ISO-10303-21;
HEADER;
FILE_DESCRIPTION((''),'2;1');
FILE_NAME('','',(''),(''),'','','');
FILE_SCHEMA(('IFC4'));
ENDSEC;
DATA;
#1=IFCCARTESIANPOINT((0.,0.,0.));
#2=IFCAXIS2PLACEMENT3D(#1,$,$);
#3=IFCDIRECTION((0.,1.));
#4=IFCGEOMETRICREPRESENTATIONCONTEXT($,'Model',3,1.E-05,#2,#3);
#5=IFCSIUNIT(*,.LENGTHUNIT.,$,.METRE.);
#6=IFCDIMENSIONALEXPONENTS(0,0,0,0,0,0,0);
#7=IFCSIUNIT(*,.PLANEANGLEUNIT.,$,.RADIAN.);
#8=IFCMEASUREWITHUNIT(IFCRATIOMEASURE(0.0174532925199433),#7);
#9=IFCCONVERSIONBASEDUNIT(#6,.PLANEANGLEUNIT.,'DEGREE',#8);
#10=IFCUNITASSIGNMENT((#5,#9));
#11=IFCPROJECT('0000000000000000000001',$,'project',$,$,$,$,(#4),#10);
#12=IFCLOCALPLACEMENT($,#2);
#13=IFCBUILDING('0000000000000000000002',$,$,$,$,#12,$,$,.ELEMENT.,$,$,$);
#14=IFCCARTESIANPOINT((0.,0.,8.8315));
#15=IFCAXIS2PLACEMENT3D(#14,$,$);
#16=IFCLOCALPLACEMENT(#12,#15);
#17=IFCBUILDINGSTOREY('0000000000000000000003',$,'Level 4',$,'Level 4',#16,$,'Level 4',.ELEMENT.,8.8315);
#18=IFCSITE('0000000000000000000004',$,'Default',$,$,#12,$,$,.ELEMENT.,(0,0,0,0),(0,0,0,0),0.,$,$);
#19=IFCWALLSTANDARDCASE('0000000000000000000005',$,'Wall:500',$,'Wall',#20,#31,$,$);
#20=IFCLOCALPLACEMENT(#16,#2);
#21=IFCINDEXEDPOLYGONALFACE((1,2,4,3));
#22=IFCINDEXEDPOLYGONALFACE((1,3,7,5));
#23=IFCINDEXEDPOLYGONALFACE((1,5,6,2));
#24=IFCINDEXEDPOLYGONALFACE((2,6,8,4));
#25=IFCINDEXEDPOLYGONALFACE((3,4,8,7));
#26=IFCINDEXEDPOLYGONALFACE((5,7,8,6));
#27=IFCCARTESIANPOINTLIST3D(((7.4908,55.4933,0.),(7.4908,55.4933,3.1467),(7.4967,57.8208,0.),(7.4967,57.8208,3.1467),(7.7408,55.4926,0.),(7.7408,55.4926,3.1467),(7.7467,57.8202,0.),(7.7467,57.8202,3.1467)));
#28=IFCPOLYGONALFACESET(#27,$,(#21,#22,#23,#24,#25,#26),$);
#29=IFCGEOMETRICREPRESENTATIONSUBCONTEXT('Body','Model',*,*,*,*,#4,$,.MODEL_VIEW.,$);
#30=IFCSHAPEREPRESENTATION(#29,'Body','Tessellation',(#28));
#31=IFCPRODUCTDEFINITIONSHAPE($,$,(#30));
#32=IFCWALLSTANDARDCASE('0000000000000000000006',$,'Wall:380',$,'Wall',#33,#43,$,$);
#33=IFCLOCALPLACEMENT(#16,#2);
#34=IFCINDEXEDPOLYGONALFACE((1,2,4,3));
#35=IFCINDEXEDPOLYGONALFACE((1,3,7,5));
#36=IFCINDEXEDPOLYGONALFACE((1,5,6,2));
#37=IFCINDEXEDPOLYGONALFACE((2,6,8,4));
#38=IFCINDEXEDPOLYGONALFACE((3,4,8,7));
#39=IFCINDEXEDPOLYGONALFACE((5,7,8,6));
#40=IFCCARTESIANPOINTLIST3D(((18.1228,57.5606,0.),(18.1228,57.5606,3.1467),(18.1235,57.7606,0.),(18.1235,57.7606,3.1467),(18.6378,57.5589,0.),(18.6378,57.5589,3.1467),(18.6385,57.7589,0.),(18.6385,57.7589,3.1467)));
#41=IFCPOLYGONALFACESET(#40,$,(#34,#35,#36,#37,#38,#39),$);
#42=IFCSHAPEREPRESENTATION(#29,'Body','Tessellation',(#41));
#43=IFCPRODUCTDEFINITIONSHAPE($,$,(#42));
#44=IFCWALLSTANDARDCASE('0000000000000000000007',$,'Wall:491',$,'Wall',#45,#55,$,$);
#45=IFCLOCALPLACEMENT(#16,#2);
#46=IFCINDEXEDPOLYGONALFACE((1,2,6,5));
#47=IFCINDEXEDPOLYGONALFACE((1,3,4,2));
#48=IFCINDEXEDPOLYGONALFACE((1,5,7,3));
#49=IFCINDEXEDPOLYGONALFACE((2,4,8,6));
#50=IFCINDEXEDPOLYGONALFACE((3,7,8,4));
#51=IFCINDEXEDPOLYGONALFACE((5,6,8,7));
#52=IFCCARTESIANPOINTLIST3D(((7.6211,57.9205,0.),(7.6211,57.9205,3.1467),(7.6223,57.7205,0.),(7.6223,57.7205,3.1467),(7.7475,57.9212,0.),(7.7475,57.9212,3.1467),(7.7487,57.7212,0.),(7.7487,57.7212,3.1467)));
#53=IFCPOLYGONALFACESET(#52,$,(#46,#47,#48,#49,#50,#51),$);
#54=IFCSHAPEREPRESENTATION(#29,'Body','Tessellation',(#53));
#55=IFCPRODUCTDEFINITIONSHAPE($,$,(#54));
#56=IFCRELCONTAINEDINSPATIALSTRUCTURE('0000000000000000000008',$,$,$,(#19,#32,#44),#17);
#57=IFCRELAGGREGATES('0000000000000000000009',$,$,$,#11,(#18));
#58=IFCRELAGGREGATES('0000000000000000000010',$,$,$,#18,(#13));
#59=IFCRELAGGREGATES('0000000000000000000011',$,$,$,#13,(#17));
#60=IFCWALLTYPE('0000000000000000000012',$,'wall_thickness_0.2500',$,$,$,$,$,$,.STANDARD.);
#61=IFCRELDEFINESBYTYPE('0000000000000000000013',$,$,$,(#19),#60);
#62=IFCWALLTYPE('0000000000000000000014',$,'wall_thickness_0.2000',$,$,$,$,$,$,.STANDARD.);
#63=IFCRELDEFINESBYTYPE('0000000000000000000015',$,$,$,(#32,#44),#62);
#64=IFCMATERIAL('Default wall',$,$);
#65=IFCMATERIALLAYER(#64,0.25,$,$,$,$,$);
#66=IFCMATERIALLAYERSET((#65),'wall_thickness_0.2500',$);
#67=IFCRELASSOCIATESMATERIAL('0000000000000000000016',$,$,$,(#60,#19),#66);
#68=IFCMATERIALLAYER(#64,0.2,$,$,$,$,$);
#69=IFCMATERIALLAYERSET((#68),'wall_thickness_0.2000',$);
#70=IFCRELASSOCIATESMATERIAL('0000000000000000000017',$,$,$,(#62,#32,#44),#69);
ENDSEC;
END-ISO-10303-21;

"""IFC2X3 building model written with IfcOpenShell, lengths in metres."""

from ifc_helpers import new_model, entity, si_unit, converted_unit, direction, frame, origin, place, context, subcontext, project, spatial, polyline, outline, extrude, material, layer, layer_set, layer_usage, type_object, element, save


model = new_model("IFC2X3")

# Units and contexts
model_context = context("Model", 3, precision=1e-05, world=origin(), true_north=direction((0.0, 1.0)))
body_context = subcontext(model_context, "Body", "Model", "MODEL_VIEW")
ifc_project = project(units=[si_unit("LENGTHUNIT", "METRE"), converted_unit("PLANEANGLEUNIT", "DEGREE", entity("IfcRatioMeasure", 0.0174532925199433), si_unit("PLANEANGLEUNIT", "RADIAN"), dimensions=[0, 0, 0, 0, 0, 0, 0])], contexts=[model_context])

# Site, building, storey
placement = place(None, origin())
site = spatial("IfcSite", under=ifc_project, at=placement, Name="Default", CompositionType="ELEMENT", RefLatitude=(0, 0, 0, 0), RefLongitude=(0, 0, 0, 0), RefElevation=0.0)
building = spatial("IfcBuilding", under=site, at=placement, CompositionType="ELEMENT")
storey_placement = place(placement, frame((0.0, 0.0, 8.8315)))
storey = spatial("IfcBuildingStorey", under=building, at=storey_placement, Name="Level 4", ObjectType="Level 4", LongName="Level 4", CompositionType="ELEMENT", Elevation=8.8315)

# Walls
ifc_material_1 = material(Name="Default wall")
ifc_layer_1 = layer(ifc_material_1, 0.25)
ifc_layer_set_1 = layer_set([ifc_layer_1], Name="wall_thickness_0.2500")
ifc_layer_usage_1 = layer_usage(ifc_layer_set_1, "AXIS2", "POSITIVE", -0.125)
wall_type_1 = type_object("IfcWallType", Name="wall_thickness_0.2500", PredefinedType="STANDARD", material=ifc_layer_set_1)
wall_1_placement = place(storey_placement, frame((7.6217, 57.8205, 0.0), z_axis=(0.0, 0.0, 1.0), x_axis=(-0.002517, -0.999997, 0.0)))
element("IfcWallStandardCase", 1, at=wall_1_placement, inside=storey, type_object=wall_type_1, material=ifc_layer_usage_1, Name="Wall:500", ObjectType="Wall", context=body_context, shape_type="SweptSolid", body=[
    extrude(outline(polyline([(2.3275, -0.125), (2.3275, 0.125), (0.0, 0.125), (0.0, -0.125), (2.3275, -0.125)])), origin(), (0.0, 0.0, 1.0), 3.1467),
])
ifc_layer_2 = layer(ifc_material_1, 0.2)
ifc_layer_set_2 = layer_set([ifc_layer_2], Name="wall_thickness_0.2000")
ifc_layer_usage_2 = layer_usage(ifc_layer_set_2, "AXIS2", "POSITIVE", -0.1)
wall_type_2 = type_object("IfcWallType", Name="wall_thickness_0.2000", PredefinedType="STANDARD", material=ifc_layer_set_2)
wall_2_placement = place(storey_placement, frame((18.1232, 57.6606, 0.0), z_axis=(0.0, 0.0, 1.0), x_axis=(0.999994, -0.003422, 0.0)))
element("IfcWallStandardCase", 2, at=wall_2_placement, inside=storey, type_object=wall_type_2, material=ifc_layer_usage_2, Name="Wall:380", ObjectType="Wall", context=body_context, shape_type="SweptSolid", body=[
    extrude(outline(polyline([(0.515, -0.1), (0.515, 0.1), (0.0, 0.1), (0.0, -0.1), (0.515, -0.1)])), origin(), (0.0, 0.0, 1.0), 3.1467),
])
wall_3_placement = place(storey_placement, frame((7.6217, 57.8205, 0.0), z_axis=(0.0, 0.0, 1.0), x_axis=(0.999984, 0.005732, 0.0)))
element("IfcWallStandardCase", 3, at=wall_3_placement, inside=storey, type_object=wall_type_2, material=ifc_layer_usage_2, Name="Wall:491", ObjectType="Wall", context=body_context, shape_type="SweptSolid", body=[
    extrude(outline(polyline([(0.1264, -0.1), (0.1264, 0.1), (0.0, 0.1), (0.0, -0.1), (0.1264, -0.1)])), origin(), (0.0, 0.0, 1.0), 3.1467),
])

save(model, "model.ifc")
